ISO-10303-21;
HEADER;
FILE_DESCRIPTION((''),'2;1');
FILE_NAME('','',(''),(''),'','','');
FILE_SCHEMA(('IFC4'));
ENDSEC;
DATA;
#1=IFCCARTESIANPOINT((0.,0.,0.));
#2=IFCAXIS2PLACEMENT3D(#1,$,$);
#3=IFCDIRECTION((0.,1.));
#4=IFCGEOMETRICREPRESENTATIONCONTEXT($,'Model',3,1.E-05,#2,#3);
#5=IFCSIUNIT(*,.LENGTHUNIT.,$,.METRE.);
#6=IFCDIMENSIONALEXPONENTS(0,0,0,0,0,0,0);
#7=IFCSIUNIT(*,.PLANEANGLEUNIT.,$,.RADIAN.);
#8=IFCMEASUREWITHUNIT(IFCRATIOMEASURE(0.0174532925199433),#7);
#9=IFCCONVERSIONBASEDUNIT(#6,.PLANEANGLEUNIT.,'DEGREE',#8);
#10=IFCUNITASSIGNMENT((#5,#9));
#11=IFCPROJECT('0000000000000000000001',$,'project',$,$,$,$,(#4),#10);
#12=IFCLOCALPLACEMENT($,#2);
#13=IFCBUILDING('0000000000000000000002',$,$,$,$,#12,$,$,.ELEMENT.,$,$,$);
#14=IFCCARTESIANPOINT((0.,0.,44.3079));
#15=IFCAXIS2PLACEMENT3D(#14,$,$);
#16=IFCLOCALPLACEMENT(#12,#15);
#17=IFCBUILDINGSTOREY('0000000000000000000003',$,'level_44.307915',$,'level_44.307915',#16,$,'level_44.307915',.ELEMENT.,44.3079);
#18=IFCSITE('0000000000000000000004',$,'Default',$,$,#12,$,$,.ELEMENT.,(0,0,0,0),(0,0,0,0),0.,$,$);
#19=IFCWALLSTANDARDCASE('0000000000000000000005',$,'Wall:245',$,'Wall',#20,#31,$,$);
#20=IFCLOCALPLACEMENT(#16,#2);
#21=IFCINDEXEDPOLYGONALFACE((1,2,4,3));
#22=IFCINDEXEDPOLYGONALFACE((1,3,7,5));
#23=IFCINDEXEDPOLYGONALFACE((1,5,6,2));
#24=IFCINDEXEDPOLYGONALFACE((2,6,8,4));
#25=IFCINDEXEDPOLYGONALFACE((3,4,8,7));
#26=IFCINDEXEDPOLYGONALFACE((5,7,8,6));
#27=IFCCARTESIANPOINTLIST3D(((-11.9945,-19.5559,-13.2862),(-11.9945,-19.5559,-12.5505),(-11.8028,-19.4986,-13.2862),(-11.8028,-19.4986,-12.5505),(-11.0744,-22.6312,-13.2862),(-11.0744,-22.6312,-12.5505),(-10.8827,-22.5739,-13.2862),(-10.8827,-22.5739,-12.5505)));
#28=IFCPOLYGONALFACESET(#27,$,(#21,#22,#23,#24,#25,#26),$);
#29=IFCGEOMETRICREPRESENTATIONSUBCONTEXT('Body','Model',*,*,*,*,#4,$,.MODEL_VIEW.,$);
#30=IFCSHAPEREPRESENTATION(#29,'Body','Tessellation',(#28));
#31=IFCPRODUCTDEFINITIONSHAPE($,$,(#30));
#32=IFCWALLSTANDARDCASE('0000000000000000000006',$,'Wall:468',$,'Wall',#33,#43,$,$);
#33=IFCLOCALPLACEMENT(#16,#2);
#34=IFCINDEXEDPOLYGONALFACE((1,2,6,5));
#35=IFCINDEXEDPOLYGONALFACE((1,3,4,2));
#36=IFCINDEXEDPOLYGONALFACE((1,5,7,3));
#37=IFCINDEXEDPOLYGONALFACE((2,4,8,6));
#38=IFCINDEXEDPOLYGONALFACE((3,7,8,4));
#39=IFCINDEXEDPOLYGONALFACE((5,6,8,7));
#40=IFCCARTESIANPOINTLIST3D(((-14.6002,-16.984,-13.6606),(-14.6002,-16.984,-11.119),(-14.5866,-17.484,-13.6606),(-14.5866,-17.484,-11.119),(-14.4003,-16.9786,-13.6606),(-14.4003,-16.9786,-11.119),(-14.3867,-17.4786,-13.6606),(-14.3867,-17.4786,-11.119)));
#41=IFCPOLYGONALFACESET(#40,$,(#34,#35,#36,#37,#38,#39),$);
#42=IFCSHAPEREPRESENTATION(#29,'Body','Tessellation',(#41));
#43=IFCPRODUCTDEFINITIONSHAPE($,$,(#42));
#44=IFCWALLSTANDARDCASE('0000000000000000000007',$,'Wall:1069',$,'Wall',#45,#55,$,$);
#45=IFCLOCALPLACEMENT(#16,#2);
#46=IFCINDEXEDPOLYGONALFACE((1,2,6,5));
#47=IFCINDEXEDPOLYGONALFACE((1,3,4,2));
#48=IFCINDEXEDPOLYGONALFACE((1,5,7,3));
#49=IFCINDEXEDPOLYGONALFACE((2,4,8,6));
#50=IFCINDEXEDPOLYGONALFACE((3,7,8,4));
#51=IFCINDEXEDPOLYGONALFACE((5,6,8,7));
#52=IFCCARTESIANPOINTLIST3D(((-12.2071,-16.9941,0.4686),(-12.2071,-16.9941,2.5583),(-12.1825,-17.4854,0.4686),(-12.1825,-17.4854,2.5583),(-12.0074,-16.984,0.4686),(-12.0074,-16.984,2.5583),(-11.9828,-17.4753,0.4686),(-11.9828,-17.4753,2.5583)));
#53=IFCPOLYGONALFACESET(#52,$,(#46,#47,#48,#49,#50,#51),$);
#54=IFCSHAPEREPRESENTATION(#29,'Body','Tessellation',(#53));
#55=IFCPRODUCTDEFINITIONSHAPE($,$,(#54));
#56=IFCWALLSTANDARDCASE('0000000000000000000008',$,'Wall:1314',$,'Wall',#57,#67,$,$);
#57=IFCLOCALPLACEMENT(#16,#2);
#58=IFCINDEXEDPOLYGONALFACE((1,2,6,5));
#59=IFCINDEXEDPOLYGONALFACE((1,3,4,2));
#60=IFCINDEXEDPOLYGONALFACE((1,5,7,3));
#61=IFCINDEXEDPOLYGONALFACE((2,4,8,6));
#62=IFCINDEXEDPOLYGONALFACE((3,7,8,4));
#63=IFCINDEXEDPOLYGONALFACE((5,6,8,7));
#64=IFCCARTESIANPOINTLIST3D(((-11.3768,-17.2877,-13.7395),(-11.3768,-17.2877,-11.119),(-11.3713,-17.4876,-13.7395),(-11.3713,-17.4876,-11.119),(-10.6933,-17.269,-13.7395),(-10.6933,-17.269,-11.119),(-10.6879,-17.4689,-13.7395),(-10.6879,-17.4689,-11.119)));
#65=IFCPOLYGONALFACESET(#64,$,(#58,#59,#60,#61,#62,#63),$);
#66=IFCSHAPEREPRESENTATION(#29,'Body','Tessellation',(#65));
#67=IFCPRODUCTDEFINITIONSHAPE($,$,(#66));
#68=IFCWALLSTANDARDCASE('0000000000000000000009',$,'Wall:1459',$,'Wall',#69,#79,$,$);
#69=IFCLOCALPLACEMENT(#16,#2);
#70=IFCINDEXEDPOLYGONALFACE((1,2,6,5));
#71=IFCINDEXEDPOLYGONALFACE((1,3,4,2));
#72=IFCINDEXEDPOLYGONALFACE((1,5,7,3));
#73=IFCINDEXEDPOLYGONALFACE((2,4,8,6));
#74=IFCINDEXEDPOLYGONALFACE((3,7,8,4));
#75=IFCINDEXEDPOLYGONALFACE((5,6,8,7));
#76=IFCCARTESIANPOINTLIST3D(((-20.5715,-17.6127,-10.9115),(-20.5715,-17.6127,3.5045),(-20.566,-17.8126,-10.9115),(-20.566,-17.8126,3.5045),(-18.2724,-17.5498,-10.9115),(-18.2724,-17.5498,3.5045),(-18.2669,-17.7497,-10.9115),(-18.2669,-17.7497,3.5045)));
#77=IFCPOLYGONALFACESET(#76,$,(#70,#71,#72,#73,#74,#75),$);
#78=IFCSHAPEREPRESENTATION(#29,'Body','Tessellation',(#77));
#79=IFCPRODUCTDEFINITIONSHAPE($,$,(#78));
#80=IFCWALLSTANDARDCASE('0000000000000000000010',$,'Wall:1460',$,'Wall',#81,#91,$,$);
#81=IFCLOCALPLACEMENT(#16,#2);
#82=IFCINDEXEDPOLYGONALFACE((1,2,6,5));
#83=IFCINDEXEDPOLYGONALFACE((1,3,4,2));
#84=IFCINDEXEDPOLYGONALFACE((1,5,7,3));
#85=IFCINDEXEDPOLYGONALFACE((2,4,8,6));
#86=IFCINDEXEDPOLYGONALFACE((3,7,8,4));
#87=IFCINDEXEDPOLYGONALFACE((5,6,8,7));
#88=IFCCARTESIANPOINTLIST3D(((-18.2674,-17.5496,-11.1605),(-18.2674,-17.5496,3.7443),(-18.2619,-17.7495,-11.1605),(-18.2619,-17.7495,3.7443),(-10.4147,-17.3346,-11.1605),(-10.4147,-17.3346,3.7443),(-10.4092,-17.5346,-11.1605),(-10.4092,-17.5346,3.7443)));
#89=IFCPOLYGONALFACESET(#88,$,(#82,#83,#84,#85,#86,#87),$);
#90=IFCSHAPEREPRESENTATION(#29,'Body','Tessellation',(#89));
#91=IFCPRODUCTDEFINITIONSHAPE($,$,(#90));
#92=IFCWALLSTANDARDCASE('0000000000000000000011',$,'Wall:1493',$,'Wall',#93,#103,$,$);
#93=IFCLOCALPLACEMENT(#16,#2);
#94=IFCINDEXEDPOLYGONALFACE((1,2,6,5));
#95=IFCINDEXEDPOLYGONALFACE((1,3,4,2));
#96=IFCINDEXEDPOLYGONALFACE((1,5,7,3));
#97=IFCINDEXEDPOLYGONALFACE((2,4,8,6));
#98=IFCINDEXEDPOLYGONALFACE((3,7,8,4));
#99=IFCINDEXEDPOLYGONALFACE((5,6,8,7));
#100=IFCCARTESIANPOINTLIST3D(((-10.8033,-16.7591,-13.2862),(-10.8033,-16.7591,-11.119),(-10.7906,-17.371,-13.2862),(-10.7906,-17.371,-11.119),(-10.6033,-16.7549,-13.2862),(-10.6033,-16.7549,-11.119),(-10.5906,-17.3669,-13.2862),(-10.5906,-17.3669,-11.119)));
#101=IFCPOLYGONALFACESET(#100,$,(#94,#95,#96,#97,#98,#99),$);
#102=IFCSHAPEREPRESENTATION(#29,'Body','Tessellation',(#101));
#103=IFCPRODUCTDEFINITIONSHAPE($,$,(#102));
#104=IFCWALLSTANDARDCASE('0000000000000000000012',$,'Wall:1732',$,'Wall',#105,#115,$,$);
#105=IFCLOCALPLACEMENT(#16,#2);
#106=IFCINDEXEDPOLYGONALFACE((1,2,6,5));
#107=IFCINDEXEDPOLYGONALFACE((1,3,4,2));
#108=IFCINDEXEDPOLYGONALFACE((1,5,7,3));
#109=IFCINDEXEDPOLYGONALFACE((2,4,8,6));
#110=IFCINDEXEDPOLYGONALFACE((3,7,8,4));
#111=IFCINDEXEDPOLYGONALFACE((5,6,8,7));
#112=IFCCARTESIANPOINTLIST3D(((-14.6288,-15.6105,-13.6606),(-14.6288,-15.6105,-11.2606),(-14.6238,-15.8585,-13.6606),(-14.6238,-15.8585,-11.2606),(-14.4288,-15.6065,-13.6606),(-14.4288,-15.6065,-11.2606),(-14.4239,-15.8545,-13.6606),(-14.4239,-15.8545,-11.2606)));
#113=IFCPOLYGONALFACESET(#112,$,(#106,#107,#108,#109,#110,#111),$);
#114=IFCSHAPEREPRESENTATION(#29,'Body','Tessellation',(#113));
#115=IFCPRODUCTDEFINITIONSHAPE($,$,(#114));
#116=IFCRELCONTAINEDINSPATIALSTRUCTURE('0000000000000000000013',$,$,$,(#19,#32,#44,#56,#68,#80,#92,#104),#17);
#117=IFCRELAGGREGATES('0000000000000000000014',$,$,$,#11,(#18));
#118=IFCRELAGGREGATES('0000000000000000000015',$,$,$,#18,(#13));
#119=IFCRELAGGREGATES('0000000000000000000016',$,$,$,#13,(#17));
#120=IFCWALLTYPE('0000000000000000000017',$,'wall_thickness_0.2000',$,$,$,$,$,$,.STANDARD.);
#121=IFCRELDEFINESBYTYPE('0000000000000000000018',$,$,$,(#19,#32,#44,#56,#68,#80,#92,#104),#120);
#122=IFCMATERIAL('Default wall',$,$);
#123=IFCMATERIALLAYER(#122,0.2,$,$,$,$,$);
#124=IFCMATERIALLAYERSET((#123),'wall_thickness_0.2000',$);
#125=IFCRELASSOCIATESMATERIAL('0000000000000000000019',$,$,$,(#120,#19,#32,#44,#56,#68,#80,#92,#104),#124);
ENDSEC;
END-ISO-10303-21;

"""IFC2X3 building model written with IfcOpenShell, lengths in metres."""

from ifc_helpers import new_model, entity, si_unit, converted_unit, direction, frame, origin, place, context, subcontext, project, spatial, polyline, outline, extrude, material, layer, layer_set, layer_usage, type_object, element, save


model = new_model("IFC2X3")

# Units and contexts
model_context = context("Model", 3, precision=1e-05, world=origin(), true_north=direction((0.0, 1.0)))
body_context = subcontext(model_context, "Body", "Model", "MODEL_VIEW")
ifc_project = project(units=[si_unit("LENGTHUNIT", "METRE"), converted_unit("PLANEANGLEUNIT", "DEGREE", entity("IfcRatioMeasure", 0.0174532925199433), si_unit("PLANEANGLEUNIT", "RADIAN"), dimensions=[0, 0, 0, 0, 0, 0, 0])], contexts=[model_context])

# Site, building, storey
placement_1 = place(None, origin())
site = spatial("IfcSite", under=ifc_project, at=placement_1, Name="Default", CompositionType="ELEMENT", RefLatitude=(0, 0, 0, 0), RefLongitude=(0, 0, 0, 0), RefElevation=0.0)
building = spatial("IfcBuilding", under=site, at=placement_1, CompositionType="ELEMENT")
storey_placement = place(placement_1, frame((0.0, 0.0, 44.3079)))
storey = spatial("IfcBuildingStorey", under=building, at=storey_placement, Name="level_44.307915", ObjectType="level_44.307915", LongName="level_44.307915", CompositionType="ELEMENT", Elevation=44.3079)

# Walls
ifc_material = material(Name="Default wall")
ifc_layer = layer(ifc_material, 0.2)
ifc_layer_set = layer_set([ifc_layer], Name="wall_thickness_0.2000")
ifc_layer_usage = layer_usage(ifc_layer_set, "AXIS2", "POSITIVE", -0.1)
wall_type = type_object("IfcWallType", Name="wall_thickness_0.2000", PredefinedType="STANDARD", material=ifc_layer_set)
placement_2 = place(placement_1, frame((0.0, 0.0, 31.0217)))
wall_1_placement = place(placement_2, frame((-11.8987, -19.5272, 0.0), z_axis=(0.0, 0.0, 1.0), x_axis=(0.286637, -0.958039, 0.0)))
element("IfcWallStandardCase", 1, at=wall_1_placement, inside=storey, type_object=wall_type, material=ifc_layer_usage, Name="Wall:245", ObjectType="Wall", context=body_context, shape_type="SweptSolid", body=[
    extrude(outline(polyline([(3.21, -0.1), (3.21, 0.1), (0.0, 0.1), (0.0, -0.1), (3.21, -0.1)])), origin(), (0.0, 0.0, 1.0), 0.7358),
])
placement_3 = place(placement_1, frame((0.0, 0.0, 30.6473)))
wall_2_placement = place(placement_3, frame((-14.4866, -17.4813, 0.0), z_axis=(0.0, 0.0, 1.0), x_axis=(-0.027325, 0.999627, 0.0)))
element("IfcWallStandardCase", 2, at=wall_2_placement, inside=storey, type_object=wall_type, material=ifc_layer_usage, Name="Wall:468", ObjectType="Wall", context=body_context, shape_type="SweptSolid", body=[
    extrude(outline(polyline([(0.5002, -0.1), (0.5002, 0.1), (0.0, 0.1), (0.0, -0.1), (0.5002, -0.1)])), origin(), (0.0, 0.0, 1.0), 2.5416),
])
placement_4 = place(placement_1, frame((0.0, 0.0, 44.7765)))
wall_3_placement = place(placement_4, frame((-12.0826, -17.4803, 0.0), z_axis=(0.0, 0.0, 1.0), x_axis=(-0.050071, 0.998746, 0.0)))
element("IfcWallStandardCase", 3, at=wall_3_placement, inside=storey, type_object=wall_type, material=ifc_layer_usage, Name="Wall:1069", ObjectType="Wall", context=body_context, shape_type="SweptSolid", body=[
    extrude(outline(polyline([(0.4919, -0.1), (0.4919, 0.1), (0.0, 0.1), (0.0, -0.1), (0.4919, -0.1)])), origin(), (0.0, 0.0, 1.0), 2.0897),
])
placement_5 = place(placement_1, frame((0.0, 0.0, 30.5684)))
wall_4_placement = place(placement_5, frame((-11.3741, -17.3876, 0.0), z_axis=(0.0, 0.0, 1.0), x_axis=(0.999626, 0.027331, 0.0)))
element("IfcWallStandardCase", 4, at=wall_4_placement, inside=storey, type_object=wall_type, material=ifc_layer_usage, Name="Wall:1314", ObjectType="Wall", context=body_context, shape_type="SweptSolid", body=[
    extrude(outline(polyline([(0.6837, -0.1), (0.6837, 0.1), (0.0, 0.1), (0.0, -0.1), (0.6837, -0.1)])), origin(), (0.0, 0.0, 1.0), 2.6205),
])
placement_6 = place(placement_1, frame((0.0, 0.0, 33.3964)))
wall_5_placement = place(placement_6, frame((-18.2696, -17.6497, 0.0), z_axis=(0.0, 0.0, 1.0), x_axis=(-0.999625, -0.027365, 0.0)))
element("IfcWallStandardCase", 5, at=wall_5_placement, inside=storey, type_object=wall_type, material=ifc_layer_usage, Name="Wall:1459", ObjectType="Wall", context=body_context, shape_type="SweptSolid", body=[
    extrude(outline(polyline([(2.3, -0.1), (2.3, 0.1), (0.0, 0.1), (0.0, -0.1), (2.3, -0.1)])), origin(), (0.0, 0.0, 1.0), 14.416),
])
placement_7 = place(placement_1, frame((0.0, 0.0, 33.1474)))
wall_6_placement = place(placement_7, frame((-10.4119, -17.4346, 0.0), z_axis=(0.0, 0.0, 1.0), x_axis=(-0.999625, -0.027365, 0.0)))
element("IfcWallStandardCase", 6, at=wall_6_placement, inside=storey, type_object=wall_type, material=ifc_layer_usage, Name="Wall:1460", ObjectType="Wall", context=body_context, shape_type="SweptSolid", body=[
    extrude(outline(polyline([(7.8557, -0.1), (7.8557, 0.1), (0.0, 0.1), (0.0, -0.1), (7.8557, -0.1)])), origin(), (0.0, 0.0, 1.0), 14.9048),
])
placement_8 = place(placement_1, frame((0.0, 0.0, 31.0217)))
wall_7_placement = place(placement_8, frame((-10.7033, -16.757, 0.0), z_axis=(0.0, 0.0, 1.0), x_axis=(0.020713, -0.999785, 0.0)))
element("IfcWallStandardCase", 7, at=wall_7_placement, inside=storey, type_object=wall_type, material=ifc_layer_usage, Name="Wall:1493", ObjectType="Wall", context=body_context, shape_type="SweptSolid", body=[
    extrude(outline(polyline([(0.6121, -0.1), (0.6121, 0.1), (0.0, 0.1), (0.0, -0.1), (0.6121, -0.1)])), origin(), (0.0, 0.0, 1.0), 2.1672),
])
placement_9 = place(placement_1, frame((0.0, 0.0, 30.6473)))
wall_8_placement = place(placement_9, frame((-14.5238, -15.8565, 0.0), z_axis=(0.0, 0.0, 1.0), x_axis=(-0.019984, 0.9998, 0.0)))
element("IfcWallStandardCase", 8, at=wall_8_placement, inside=storey, type_object=wall_type, material=ifc_layer_usage, Name="Wall:1732", ObjectType="Wall", context=body_context, shape_type="SweptSolid", body=[
    extrude(outline(polyline([(0.248, -0.1), (0.248, 0.1), (0.0, 0.1), (0.0, -0.1), (0.248, -0.1)])), origin(), (0.0, 0.0, 1.0), 2.4),
])

save(model, "model.ifc")
